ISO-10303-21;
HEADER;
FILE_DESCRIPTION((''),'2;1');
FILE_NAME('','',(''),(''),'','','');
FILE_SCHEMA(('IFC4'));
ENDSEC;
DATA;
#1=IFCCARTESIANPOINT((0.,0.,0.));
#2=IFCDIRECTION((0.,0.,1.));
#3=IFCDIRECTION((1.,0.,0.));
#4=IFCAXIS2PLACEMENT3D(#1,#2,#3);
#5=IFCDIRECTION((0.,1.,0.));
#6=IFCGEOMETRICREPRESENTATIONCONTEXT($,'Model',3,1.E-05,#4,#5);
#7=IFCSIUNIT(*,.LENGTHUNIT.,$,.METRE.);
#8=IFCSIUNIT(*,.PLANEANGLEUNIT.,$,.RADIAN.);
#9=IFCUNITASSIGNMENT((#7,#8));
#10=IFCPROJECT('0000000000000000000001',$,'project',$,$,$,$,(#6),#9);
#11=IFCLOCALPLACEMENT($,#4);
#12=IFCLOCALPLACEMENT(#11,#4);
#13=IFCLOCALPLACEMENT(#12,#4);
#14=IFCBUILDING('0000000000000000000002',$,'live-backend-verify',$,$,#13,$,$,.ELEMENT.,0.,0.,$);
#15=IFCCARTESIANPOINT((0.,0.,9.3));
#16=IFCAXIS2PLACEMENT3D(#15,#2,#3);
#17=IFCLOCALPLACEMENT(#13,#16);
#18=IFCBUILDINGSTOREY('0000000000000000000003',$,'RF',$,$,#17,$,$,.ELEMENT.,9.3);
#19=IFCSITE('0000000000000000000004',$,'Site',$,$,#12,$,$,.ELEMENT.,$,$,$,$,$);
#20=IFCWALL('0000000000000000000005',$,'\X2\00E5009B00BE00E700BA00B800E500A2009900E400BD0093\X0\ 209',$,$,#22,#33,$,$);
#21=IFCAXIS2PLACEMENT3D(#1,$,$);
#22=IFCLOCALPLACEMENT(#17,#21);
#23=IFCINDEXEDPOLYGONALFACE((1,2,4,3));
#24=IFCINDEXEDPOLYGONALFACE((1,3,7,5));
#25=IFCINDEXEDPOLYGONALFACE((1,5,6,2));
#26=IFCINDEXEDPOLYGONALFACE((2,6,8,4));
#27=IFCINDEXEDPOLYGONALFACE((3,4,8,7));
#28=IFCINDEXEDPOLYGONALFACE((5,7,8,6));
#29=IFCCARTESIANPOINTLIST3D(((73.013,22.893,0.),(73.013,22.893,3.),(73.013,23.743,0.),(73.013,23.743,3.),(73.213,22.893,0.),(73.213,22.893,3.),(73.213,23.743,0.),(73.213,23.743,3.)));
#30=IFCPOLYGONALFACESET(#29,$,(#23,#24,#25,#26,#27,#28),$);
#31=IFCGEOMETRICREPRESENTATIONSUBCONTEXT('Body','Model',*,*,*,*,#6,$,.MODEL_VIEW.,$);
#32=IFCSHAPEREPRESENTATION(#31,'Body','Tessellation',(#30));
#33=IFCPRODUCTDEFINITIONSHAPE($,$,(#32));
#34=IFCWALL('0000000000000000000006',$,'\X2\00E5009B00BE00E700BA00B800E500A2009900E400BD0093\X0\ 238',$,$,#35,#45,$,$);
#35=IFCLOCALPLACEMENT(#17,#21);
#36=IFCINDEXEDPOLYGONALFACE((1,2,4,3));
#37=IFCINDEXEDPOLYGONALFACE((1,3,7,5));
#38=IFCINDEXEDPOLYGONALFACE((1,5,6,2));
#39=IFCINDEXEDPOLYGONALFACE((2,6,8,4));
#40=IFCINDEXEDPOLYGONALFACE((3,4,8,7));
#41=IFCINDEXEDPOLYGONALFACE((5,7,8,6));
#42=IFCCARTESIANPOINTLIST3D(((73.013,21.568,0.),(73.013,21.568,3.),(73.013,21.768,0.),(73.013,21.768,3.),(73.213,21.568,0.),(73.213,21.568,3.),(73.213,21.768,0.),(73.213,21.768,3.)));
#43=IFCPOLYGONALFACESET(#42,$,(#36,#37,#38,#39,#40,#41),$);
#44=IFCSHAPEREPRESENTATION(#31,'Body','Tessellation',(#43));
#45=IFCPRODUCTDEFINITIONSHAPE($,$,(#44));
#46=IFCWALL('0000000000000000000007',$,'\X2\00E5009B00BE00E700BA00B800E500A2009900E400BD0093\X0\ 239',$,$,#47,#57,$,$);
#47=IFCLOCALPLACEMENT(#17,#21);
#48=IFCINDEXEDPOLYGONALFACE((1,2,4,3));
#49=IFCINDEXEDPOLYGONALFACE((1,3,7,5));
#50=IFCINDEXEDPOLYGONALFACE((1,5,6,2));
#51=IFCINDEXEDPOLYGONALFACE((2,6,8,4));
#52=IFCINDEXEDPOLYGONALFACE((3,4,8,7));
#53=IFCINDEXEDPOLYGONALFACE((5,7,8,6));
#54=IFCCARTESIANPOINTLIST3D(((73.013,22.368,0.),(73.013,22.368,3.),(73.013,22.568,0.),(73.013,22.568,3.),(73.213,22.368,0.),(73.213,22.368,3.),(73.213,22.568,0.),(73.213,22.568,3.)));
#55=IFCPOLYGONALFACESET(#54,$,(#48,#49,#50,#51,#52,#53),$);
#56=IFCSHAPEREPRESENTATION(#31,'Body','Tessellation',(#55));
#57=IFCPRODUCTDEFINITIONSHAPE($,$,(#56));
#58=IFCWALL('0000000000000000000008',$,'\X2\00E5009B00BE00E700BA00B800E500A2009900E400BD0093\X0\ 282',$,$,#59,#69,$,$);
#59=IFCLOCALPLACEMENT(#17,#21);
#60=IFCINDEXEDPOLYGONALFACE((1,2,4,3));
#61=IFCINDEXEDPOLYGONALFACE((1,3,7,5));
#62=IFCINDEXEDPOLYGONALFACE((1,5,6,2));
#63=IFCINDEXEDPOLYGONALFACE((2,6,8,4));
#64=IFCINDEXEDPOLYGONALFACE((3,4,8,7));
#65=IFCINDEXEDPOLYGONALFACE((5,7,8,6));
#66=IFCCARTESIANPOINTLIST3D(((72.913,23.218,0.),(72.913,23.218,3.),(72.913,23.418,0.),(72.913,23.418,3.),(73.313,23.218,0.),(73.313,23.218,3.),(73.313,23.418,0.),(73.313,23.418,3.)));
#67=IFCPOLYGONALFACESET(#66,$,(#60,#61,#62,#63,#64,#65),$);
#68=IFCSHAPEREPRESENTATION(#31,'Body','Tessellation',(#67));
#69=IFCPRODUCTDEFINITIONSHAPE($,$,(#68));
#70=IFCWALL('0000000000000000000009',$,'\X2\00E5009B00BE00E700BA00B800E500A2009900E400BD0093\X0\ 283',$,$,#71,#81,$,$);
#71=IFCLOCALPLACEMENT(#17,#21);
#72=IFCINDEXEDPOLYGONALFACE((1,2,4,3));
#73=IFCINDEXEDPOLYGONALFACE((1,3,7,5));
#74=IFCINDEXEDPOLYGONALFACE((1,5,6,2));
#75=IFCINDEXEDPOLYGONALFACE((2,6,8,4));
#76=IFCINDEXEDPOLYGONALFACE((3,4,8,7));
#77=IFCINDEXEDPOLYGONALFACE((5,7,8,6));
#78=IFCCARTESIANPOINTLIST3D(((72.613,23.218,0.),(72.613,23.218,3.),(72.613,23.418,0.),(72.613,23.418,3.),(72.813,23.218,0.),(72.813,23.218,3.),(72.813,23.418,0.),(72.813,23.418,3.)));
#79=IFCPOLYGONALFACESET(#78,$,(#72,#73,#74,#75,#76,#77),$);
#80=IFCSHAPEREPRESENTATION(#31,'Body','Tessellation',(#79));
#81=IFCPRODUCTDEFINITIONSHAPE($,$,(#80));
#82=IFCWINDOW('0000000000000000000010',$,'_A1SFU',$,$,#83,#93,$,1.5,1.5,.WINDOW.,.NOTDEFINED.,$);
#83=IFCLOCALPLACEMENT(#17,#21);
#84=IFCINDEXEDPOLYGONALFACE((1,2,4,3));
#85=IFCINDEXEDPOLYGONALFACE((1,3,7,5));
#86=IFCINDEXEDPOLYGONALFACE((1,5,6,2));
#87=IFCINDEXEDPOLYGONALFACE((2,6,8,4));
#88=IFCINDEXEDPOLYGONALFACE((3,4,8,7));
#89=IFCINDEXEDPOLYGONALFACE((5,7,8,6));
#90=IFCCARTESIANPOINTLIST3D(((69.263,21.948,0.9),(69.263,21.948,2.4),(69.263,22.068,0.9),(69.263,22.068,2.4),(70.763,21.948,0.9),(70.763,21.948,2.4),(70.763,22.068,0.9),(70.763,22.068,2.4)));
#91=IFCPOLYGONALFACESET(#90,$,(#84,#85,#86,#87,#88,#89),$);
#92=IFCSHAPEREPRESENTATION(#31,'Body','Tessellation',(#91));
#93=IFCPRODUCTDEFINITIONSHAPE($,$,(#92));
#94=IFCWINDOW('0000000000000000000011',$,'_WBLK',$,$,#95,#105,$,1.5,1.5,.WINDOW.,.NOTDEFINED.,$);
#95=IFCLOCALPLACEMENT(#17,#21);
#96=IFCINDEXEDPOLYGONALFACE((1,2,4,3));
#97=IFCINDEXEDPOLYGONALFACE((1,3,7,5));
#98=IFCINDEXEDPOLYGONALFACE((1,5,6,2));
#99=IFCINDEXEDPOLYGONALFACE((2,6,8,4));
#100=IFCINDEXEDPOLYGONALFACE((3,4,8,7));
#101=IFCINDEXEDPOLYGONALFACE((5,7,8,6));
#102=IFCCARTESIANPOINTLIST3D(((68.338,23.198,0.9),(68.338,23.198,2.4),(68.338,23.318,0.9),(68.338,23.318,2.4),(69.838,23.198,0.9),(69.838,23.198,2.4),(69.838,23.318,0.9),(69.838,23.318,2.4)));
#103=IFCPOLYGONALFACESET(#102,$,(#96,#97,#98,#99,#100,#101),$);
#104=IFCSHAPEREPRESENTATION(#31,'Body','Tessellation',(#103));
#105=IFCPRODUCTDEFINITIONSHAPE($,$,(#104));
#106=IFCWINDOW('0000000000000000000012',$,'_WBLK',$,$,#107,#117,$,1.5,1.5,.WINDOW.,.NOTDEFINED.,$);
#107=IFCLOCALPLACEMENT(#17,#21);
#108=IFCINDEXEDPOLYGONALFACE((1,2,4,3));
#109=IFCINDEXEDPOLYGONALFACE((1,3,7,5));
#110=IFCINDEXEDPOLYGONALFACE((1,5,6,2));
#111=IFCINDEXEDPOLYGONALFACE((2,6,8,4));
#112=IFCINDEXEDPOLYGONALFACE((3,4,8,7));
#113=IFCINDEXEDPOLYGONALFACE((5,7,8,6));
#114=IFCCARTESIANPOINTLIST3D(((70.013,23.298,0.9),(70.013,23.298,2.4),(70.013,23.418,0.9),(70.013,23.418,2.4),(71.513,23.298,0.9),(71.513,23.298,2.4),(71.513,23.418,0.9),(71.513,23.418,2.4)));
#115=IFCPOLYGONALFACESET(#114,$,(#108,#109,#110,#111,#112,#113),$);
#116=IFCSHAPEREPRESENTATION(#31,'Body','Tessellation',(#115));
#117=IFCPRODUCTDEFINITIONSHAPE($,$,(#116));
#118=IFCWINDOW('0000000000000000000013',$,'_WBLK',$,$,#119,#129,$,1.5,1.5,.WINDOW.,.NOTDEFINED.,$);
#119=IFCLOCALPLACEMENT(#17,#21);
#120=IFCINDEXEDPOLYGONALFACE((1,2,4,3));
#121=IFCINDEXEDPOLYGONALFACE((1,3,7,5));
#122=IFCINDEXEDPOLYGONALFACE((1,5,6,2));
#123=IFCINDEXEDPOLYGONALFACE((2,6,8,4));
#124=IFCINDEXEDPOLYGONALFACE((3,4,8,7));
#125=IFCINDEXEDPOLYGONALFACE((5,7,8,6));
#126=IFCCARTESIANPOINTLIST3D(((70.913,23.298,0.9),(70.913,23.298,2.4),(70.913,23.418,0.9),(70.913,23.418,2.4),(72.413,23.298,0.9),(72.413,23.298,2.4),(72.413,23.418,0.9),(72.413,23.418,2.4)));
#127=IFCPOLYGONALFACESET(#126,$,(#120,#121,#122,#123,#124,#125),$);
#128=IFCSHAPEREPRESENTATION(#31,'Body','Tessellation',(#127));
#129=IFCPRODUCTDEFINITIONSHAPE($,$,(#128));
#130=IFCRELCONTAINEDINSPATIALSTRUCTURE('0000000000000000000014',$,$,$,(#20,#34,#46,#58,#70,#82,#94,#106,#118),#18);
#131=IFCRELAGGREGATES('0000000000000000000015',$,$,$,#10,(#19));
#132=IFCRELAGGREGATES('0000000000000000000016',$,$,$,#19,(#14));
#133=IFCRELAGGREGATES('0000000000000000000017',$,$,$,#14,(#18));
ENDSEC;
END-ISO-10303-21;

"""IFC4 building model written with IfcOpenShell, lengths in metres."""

from ifc_helpers import new_model, si_unit, direction, frame, frame_2d, origin_with_axes, place, context, subcontext, project, spatial, rectangle, extrude, element, save


model = new_model("IFC4")

# Units and contexts
model_context = context("Model", 3, precision=1e-05, world=origin_with_axes(), true_north=direction((0.0, 1.0, 0.0)))
body_context = subcontext(model_context, "Body", "Model", "MODEL_VIEW")
ifc_project = project(units=[si_unit("LENGTHUNIT", "METRE"), si_unit("PLANEANGLEUNIT", "RADIAN")], contexts=[model_context])

# Site, building, storey
placement = place(None, origin_with_axes())
site_placement = place(placement, origin_with_axes())
site = spatial("IfcSite", under=ifc_project, at=site_placement, Name="Site", CompositionType="ELEMENT")
building_placement = place(site_placement, origin_with_axes())
building = spatial("IfcBuilding", under=site, at=building_placement, Name="live-backend-verify", CompositionType="ELEMENT", ElevationOfRefHeight=0.0, ElevationOfTerrain=0.0)
storey_placement = place(building_placement, frame((0.0, 0.0, 9.3), z_axis=(0.0, 0.0, 1.0), x_axis=(1.0, 0.0, 0.0)))
storey = spatial("IfcBuildingStorey", under=building, at=storey_placement, Name="RF", CompositionType="ELEMENT", Elevation=9.3)

# Walls
for number, where, z_axis, x_axis, name in (
    (1, (73.113, 23.318, 0.0), (0.0, 0.0, 1.0), (0.0, -1.0, 0.0), "å\u009b¾çº¸å¢\u0099ä½\u0093 209"),
):
    element("IfcWall", number, at=place(storey_placement, frame(where, z_axis=z_axis, x_axis=x_axis)), inside=storey, Name=name, context=body_context, shape_type="SweptSolid", body=[
        extrude(rectangle(XDim=0.85, YDim=0.2, at=frame_2d((0.0, 0.0), x_axis=(1.0, 0.0, 0.0))), frame((0.0, 0.0, 0.0), z_axis=(0.0, 0.0, 1.0)), (0.0, 0.0, 1.0), 3.0),
    ])
for number, where, z_axis, x_axis, name in (
    (2, (73.113, 21.668, 0.0), (0.0, 0.0, 1.0), (0.0, -1.0, 0.0), "å\u009b¾çº¸å¢\u0099ä½\u0093 238"),
    (3, (73.113, 22.468, 0.0), (0.0, 0.0, 1.0), (1.0, 0.0, 0.0), "å\u009b¾çº¸å¢\u0099ä½\u0093 239"),
):
    element("IfcWall", number, at=place(storey_placement, frame(where, z_axis=z_axis, x_axis=x_axis)), inside=storey, Name=name, context=body_context, shape_type="SweptSolid", body=[
        extrude(rectangle(XDim=0.2, YDim=0.2, at=frame_2d((0.0, 0.0), x_axis=(1.0, 0.0, 0.0))), frame((0.0, 0.0, 0.0), z_axis=(0.0, 0.0, 1.0)), (0.0, 0.0, 1.0), 3.0),
    ])
wall_1_placement = place(storey_placement, frame((73.113, 23.318, 0.0), z_axis=(0.0, 0.0, 1.0), x_axis=(-1.0, 0.0, 0.0)))
element("IfcWall", 4, at=wall_1_placement, inside=storey, Name="å\u009b¾çº¸å¢\u0099ä½\u0093 282", context=body_context, shape_type="SweptSolid", body=[
    extrude(rectangle(XDim=0.4, YDim=0.2, at=frame_2d((0.0, 0.0), x_axis=(1.0, 0.0, 0.0))), frame((0.0, 0.0, 0.0), z_axis=(0.0, 0.0, 1.0)), (0.0, 0.0, 1.0), 3.0),
])
for number, where, z_axis, x_axis, name in (
    (5, (72.713, 23.318, 0.0), (0.0, 0.0, 1.0), (0.0, 1.0, 0.0), "å\u009b¾çº¸å¢\u0099ä½\u0093 283"),
):
    element("IfcWall", number, at=place(storey_placement, frame(where, z_axis=z_axis, x_axis=x_axis)), inside=storey, Name=name, context=body_context, shape_type="SweptSolid", body=[
        extrude(rectangle(XDim=0.2, YDim=0.2, at=frame_2d((0.0, 0.0), x_axis=(1.0, 0.0, 0.0))), frame((0.0, 0.0, 0.0), z_axis=(0.0, 0.0, 1.0)), (0.0, 0.0, 1.0), 3.0),
    ])

# Windows
for number, where, z_axis, x_axis, name in (
    (6, (70.013, 22.008, 0.9), (0.0, 0.0, 1.0), (1.0, 0.0, 0.0), "_A1SFU"),
    (7, (69.088, 23.258, 0.9), (0.0, 0.0, 1.0), (1.0, 0.0, 0.0), "_WBLK"),
    (8, (70.763, 23.358, 0.9), (0.0, 0.0, 1.0), (1.0, 0.0, 0.0), "_WBLK"),
    (9, (71.663, 23.358, 0.9), (0.0, 0.0, 1.0), (1.0, 0.0, 0.0), "_WBLK"),
):
    element("IfcWindow", number, at=place(storey_placement, frame(where, z_axis=z_axis, x_axis=x_axis)), inside=storey, Name=name, OverallHeight=1.5, OverallWidth=1.5, PartitioningType="NOTDEFINED", PredefinedType="WINDOW", context=body_context, shape_type="SweptSolid", body=[
        extrude(rectangle(XDim=1.5, YDim=0.12, at=frame_2d((0.0, 0.0), x_axis=(1.0, 0.0, 0.0))), frame((0.0, 0.0, 0.0), z_axis=(0.0, 0.0, 1.0)), (0.0, 0.0, 1.0), 1.5),
    ])

save(model, "model.ifc")
